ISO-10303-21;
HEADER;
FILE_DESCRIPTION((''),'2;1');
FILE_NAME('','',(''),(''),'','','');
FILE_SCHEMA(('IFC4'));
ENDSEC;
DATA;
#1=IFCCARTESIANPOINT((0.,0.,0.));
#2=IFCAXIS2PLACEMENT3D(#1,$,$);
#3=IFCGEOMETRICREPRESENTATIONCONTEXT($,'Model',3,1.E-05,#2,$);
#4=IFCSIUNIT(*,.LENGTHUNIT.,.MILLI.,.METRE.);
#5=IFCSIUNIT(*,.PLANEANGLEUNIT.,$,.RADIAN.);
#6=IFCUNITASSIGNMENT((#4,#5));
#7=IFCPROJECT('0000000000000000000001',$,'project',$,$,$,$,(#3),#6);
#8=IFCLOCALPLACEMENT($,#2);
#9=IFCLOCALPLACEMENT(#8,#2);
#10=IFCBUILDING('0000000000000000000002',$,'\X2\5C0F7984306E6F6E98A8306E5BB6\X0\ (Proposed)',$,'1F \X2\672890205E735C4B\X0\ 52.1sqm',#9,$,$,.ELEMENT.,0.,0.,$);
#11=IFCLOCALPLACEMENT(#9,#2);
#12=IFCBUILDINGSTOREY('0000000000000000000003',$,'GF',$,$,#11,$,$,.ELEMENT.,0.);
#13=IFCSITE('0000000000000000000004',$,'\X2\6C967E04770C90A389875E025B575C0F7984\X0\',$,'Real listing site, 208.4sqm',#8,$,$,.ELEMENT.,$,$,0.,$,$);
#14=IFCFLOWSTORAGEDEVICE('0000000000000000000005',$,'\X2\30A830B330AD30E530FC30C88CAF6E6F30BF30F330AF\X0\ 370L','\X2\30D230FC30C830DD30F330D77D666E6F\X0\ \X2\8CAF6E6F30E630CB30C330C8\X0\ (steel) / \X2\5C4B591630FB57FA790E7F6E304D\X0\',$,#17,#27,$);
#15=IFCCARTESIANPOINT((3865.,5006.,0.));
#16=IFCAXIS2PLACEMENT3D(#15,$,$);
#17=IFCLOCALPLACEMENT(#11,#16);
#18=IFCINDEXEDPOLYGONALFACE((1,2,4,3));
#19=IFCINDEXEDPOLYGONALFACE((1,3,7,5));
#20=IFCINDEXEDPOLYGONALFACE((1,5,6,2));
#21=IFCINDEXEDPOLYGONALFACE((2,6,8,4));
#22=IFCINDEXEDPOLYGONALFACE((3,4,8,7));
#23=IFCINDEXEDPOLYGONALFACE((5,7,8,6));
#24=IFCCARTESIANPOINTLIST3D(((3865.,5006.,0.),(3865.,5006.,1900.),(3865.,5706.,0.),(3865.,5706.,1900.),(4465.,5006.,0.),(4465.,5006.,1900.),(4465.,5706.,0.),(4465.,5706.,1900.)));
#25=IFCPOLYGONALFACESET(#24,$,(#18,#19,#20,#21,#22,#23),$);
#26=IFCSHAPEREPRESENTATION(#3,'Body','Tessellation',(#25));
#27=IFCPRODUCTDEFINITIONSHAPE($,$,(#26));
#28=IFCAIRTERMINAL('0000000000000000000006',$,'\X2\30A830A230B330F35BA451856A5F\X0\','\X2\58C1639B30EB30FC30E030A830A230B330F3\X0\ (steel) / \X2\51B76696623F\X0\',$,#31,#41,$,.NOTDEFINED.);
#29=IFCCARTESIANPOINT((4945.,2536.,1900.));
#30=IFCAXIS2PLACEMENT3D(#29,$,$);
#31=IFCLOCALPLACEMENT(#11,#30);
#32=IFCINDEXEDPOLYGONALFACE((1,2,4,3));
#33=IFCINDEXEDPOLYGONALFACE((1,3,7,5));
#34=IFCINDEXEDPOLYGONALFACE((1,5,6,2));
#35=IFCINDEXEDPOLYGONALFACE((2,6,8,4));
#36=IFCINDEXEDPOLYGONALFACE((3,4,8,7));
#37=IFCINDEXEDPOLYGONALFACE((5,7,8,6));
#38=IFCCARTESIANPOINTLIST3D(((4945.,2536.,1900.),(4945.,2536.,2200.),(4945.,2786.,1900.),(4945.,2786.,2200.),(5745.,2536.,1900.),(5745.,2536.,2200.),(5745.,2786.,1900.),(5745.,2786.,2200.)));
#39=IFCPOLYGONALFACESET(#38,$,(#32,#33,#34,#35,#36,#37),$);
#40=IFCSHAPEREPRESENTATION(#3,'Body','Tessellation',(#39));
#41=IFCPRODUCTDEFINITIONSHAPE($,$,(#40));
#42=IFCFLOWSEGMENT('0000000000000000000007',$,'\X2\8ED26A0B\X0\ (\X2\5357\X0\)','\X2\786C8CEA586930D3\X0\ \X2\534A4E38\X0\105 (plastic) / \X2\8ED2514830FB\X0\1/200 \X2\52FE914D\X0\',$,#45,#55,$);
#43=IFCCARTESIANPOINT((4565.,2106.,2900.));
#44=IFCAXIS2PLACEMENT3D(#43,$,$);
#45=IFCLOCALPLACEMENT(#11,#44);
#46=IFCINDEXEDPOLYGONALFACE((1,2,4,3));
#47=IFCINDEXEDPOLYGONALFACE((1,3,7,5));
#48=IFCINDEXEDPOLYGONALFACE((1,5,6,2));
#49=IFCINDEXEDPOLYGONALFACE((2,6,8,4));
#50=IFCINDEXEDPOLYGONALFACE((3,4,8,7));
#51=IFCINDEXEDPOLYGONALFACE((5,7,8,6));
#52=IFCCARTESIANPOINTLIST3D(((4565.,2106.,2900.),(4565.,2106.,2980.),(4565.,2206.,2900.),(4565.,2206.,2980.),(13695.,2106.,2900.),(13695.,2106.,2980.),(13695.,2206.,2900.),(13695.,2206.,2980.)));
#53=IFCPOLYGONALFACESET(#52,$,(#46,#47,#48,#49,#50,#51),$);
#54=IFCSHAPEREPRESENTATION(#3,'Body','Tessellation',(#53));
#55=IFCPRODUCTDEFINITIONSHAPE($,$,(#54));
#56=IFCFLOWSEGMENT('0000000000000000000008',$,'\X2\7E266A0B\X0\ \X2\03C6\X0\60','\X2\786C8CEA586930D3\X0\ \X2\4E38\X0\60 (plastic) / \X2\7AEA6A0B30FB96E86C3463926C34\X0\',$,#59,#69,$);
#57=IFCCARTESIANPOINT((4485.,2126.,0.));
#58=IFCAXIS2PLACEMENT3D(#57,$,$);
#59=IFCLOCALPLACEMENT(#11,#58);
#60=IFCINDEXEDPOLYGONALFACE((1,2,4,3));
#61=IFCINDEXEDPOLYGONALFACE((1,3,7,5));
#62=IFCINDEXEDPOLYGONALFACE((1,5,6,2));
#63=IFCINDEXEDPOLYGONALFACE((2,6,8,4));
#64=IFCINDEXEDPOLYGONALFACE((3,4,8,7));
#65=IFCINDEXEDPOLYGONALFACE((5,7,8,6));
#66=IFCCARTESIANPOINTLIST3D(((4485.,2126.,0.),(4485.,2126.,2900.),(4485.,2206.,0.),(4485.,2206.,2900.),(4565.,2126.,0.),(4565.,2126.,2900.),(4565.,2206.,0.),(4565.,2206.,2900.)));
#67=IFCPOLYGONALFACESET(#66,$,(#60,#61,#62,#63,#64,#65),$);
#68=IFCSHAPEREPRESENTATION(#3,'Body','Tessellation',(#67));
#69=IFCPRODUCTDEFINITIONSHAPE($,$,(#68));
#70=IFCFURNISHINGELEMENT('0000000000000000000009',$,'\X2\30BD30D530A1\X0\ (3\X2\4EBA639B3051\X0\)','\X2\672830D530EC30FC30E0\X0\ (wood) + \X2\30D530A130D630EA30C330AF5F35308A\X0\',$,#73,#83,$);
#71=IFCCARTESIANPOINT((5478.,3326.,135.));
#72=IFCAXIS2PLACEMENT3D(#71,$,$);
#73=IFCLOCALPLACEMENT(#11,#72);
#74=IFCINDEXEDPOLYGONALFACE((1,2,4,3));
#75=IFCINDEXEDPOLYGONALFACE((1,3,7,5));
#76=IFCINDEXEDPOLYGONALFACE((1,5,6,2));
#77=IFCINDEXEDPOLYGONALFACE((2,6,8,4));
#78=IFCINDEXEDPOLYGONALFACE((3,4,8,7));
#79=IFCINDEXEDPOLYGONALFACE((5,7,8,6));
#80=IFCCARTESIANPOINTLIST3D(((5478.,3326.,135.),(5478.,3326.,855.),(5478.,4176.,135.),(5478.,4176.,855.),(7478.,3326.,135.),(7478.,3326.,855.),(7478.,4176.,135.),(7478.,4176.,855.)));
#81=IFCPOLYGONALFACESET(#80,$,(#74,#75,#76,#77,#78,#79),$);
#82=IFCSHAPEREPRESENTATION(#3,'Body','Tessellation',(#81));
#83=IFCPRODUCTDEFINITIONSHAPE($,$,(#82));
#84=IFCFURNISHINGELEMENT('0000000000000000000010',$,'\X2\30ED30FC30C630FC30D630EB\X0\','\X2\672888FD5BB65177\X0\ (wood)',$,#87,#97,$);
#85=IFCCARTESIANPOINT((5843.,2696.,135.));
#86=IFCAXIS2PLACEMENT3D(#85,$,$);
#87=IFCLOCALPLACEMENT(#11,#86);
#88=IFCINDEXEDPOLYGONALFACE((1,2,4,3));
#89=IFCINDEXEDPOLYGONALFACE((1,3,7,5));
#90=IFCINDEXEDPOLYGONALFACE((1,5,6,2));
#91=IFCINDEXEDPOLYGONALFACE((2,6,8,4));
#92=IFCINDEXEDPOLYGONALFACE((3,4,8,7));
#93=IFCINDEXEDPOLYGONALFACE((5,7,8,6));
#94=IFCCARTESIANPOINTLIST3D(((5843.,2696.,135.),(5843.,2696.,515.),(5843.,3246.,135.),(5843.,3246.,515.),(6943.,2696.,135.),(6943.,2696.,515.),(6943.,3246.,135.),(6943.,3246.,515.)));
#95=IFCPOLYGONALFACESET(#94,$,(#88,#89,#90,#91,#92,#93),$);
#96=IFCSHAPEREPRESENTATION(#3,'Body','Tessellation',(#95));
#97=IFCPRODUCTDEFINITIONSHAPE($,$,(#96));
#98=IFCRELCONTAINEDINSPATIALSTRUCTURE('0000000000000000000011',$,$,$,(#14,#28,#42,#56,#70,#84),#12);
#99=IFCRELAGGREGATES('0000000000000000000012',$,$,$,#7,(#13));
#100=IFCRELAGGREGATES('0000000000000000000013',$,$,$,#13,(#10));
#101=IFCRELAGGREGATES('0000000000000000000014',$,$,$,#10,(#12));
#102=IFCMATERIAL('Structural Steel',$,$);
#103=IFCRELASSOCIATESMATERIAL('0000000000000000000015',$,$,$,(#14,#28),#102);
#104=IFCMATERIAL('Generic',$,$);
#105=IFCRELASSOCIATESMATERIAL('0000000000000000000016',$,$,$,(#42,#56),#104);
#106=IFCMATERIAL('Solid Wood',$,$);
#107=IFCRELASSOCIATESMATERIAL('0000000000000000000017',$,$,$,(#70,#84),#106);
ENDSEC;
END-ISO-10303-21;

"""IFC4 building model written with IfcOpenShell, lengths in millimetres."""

from ifc_helpers import new_model, si_unit, frame, frame_2d, origin, place, context, project, spatial, rectangle, extrude, material, element, save


model = new_model("IFC4")

# Units and contexts
model_context = context("Model", 3, precision=1e-05, world=origin())
ifc_project = project(units=[si_unit("LENGTHUNIT", "METRE", prefix="MILLI"), si_unit("PLANEANGLEUNIT", "RADIAN")], contexts=[model_context])

# Site, building, storey
site_placement = place(None, origin())
site = spatial("IfcSite", under=ifc_project, at=site_placement, Name="沖縄県那覇市字小禄", ObjectType="Real listing site, 208.4sqm", CompositionType="ELEMENT", RefElevation=0.0)
building_placement = place(site_placement, origin())
building = spatial("IfcBuilding", under=site, at=building_placement, Name="小禄の潮風の家 (Proposed)", ObjectType="1F 木造平屋 52.1sqm", CompositionType="ELEMENT", ElevationOfRefHeight=0.0, ElevationOfTerrain=0.0)
storey_placement = place(building_placement, origin())
storey = spatial("IfcBuildingStorey", under=building, at=storey_placement, Name="GF", CompositionType="ELEMENT", Elevation=0.0)

# Shared definitions
ifc_material_1 = material(Name="Solid Wood")

# Shared definitions
ifc_material_2 = material(Name="Structural Steel")

# Shared definitions
ifc_material_3 = material(Name="Generic")

# Flow storage device
flow_storage_device_placement = place(storey_placement, frame((3865.0, 5006.0, 0.0)))
element("IfcFlowStorageDevice", 1, at=flow_storage_device_placement, inside=storey, material=ifc_material_2, Name="エコキュート貯湯タンク 370L", Description="ヒートポンプ給湯 貯湯ユニット (steel) / 屋外・基礎置き", context=model_context, shape_type="SweptSolid", body=[
    extrude(rectangle(XDim=600.0, YDim=700.0, at=frame_2d((300.0, 350.0))), frame((3865.0, 5006.0, 0.0)), (0.0, 0.0, 1.0), 1900.0),
])

# Air terminal
air_terminal_placement = place(storey_placement, frame((4945.0, 2536.0, 1900.0)))
element("IfcAirTerminal", 2, at=air_terminal_placement, inside=storey, material=ifc_material_2, Name="エアコン室内機", Description="壁掛ルームエアコン (steel) / 冷暖房", PredefinedType="NOTDEFINED", context=model_context, shape_type="SweptSolid", body=[
    extrude(rectangle(XDim=800.0, YDim=250.0, at=frame_2d((400.0, 125.0))), frame((4945.0, 2536.0, 1900.0)), (0.0, 0.0, 1.0), 300.0),
])

# Flow segments
flow_segment_1_placement = place(storey_placement, frame((4565.0, 2106.0, 2900.0)))
element("IfcFlowSegment", 3, at=flow_segment_1_placement, inside=storey, material=ifc_material_3, Name="軒樋 (南)", Description="硬質塩ビ 半丸105 (plastic) / 軒先・1/200 勾配", context=model_context, shape_type="SweptSolid", body=[
    extrude(rectangle(XDim=9130.0, YDim=100.0, at=frame_2d((4565.0, 50.0))), frame((4565.0, 2106.0, 2900.0)), (0.0, 0.0, 1.0), 80.0),
])
flow_segment_2_placement = place(storey_placement, frame((4485.0, 2126.0, 0.0)))
element("IfcFlowSegment", 4, at=flow_segment_2_placement, inside=storey, material=ifc_material_3, Name="縦樋 φ60", Description="硬質塩ビ 丸60 (plastic) / 竪樋・雨水排水", context=model_context, shape_type="SweptSolid", body=[
    extrude(rectangle(XDim=80.0, YDim=80.0, at=frame_2d((40.0, 40.0))), frame((4485.0, 2126.0, 0.0)), (0.0, 0.0, 1.0), 2900.0),
])

# Furnishing elements
furnishing_1_placement = place(storey_placement, frame((5478.0, 3326.0, 135.0)))
element("IfcFurnishingElement", 5, at=furnishing_1_placement, inside=storey, material=ifc_material_1, Name="ソファ (3人掛け)", Description="木フレーム (wood) + ファブリック張り", context=model_context, shape_type="SweptSolid", body=[
    extrude(rectangle(XDim=2000.0, YDim=850.0, at=frame_2d((1000.0, 425.0))), frame((5478.0, 3326.0, 135.0)), (0.0, 0.0, 1.0), 720.0),
])
furnishing_2_placement = place(storey_placement, frame((5843.0, 2696.0, 135.0)))
element("IfcFurnishingElement", 6, at=furnishing_2_placement, inside=storey, material=ifc_material_1, Name="ローテーブル", Description="木製家具 (wood)", context=model_context, shape_type="SweptSolid", body=[
    extrude(rectangle(XDim=1100.0, YDim=550.0, at=frame_2d((550.0, 275.0))), frame((5843.0, 2696.0, 135.0)), (0.0, 0.0, 1.0), 380.0),
])

save(model, "model.ifc")
